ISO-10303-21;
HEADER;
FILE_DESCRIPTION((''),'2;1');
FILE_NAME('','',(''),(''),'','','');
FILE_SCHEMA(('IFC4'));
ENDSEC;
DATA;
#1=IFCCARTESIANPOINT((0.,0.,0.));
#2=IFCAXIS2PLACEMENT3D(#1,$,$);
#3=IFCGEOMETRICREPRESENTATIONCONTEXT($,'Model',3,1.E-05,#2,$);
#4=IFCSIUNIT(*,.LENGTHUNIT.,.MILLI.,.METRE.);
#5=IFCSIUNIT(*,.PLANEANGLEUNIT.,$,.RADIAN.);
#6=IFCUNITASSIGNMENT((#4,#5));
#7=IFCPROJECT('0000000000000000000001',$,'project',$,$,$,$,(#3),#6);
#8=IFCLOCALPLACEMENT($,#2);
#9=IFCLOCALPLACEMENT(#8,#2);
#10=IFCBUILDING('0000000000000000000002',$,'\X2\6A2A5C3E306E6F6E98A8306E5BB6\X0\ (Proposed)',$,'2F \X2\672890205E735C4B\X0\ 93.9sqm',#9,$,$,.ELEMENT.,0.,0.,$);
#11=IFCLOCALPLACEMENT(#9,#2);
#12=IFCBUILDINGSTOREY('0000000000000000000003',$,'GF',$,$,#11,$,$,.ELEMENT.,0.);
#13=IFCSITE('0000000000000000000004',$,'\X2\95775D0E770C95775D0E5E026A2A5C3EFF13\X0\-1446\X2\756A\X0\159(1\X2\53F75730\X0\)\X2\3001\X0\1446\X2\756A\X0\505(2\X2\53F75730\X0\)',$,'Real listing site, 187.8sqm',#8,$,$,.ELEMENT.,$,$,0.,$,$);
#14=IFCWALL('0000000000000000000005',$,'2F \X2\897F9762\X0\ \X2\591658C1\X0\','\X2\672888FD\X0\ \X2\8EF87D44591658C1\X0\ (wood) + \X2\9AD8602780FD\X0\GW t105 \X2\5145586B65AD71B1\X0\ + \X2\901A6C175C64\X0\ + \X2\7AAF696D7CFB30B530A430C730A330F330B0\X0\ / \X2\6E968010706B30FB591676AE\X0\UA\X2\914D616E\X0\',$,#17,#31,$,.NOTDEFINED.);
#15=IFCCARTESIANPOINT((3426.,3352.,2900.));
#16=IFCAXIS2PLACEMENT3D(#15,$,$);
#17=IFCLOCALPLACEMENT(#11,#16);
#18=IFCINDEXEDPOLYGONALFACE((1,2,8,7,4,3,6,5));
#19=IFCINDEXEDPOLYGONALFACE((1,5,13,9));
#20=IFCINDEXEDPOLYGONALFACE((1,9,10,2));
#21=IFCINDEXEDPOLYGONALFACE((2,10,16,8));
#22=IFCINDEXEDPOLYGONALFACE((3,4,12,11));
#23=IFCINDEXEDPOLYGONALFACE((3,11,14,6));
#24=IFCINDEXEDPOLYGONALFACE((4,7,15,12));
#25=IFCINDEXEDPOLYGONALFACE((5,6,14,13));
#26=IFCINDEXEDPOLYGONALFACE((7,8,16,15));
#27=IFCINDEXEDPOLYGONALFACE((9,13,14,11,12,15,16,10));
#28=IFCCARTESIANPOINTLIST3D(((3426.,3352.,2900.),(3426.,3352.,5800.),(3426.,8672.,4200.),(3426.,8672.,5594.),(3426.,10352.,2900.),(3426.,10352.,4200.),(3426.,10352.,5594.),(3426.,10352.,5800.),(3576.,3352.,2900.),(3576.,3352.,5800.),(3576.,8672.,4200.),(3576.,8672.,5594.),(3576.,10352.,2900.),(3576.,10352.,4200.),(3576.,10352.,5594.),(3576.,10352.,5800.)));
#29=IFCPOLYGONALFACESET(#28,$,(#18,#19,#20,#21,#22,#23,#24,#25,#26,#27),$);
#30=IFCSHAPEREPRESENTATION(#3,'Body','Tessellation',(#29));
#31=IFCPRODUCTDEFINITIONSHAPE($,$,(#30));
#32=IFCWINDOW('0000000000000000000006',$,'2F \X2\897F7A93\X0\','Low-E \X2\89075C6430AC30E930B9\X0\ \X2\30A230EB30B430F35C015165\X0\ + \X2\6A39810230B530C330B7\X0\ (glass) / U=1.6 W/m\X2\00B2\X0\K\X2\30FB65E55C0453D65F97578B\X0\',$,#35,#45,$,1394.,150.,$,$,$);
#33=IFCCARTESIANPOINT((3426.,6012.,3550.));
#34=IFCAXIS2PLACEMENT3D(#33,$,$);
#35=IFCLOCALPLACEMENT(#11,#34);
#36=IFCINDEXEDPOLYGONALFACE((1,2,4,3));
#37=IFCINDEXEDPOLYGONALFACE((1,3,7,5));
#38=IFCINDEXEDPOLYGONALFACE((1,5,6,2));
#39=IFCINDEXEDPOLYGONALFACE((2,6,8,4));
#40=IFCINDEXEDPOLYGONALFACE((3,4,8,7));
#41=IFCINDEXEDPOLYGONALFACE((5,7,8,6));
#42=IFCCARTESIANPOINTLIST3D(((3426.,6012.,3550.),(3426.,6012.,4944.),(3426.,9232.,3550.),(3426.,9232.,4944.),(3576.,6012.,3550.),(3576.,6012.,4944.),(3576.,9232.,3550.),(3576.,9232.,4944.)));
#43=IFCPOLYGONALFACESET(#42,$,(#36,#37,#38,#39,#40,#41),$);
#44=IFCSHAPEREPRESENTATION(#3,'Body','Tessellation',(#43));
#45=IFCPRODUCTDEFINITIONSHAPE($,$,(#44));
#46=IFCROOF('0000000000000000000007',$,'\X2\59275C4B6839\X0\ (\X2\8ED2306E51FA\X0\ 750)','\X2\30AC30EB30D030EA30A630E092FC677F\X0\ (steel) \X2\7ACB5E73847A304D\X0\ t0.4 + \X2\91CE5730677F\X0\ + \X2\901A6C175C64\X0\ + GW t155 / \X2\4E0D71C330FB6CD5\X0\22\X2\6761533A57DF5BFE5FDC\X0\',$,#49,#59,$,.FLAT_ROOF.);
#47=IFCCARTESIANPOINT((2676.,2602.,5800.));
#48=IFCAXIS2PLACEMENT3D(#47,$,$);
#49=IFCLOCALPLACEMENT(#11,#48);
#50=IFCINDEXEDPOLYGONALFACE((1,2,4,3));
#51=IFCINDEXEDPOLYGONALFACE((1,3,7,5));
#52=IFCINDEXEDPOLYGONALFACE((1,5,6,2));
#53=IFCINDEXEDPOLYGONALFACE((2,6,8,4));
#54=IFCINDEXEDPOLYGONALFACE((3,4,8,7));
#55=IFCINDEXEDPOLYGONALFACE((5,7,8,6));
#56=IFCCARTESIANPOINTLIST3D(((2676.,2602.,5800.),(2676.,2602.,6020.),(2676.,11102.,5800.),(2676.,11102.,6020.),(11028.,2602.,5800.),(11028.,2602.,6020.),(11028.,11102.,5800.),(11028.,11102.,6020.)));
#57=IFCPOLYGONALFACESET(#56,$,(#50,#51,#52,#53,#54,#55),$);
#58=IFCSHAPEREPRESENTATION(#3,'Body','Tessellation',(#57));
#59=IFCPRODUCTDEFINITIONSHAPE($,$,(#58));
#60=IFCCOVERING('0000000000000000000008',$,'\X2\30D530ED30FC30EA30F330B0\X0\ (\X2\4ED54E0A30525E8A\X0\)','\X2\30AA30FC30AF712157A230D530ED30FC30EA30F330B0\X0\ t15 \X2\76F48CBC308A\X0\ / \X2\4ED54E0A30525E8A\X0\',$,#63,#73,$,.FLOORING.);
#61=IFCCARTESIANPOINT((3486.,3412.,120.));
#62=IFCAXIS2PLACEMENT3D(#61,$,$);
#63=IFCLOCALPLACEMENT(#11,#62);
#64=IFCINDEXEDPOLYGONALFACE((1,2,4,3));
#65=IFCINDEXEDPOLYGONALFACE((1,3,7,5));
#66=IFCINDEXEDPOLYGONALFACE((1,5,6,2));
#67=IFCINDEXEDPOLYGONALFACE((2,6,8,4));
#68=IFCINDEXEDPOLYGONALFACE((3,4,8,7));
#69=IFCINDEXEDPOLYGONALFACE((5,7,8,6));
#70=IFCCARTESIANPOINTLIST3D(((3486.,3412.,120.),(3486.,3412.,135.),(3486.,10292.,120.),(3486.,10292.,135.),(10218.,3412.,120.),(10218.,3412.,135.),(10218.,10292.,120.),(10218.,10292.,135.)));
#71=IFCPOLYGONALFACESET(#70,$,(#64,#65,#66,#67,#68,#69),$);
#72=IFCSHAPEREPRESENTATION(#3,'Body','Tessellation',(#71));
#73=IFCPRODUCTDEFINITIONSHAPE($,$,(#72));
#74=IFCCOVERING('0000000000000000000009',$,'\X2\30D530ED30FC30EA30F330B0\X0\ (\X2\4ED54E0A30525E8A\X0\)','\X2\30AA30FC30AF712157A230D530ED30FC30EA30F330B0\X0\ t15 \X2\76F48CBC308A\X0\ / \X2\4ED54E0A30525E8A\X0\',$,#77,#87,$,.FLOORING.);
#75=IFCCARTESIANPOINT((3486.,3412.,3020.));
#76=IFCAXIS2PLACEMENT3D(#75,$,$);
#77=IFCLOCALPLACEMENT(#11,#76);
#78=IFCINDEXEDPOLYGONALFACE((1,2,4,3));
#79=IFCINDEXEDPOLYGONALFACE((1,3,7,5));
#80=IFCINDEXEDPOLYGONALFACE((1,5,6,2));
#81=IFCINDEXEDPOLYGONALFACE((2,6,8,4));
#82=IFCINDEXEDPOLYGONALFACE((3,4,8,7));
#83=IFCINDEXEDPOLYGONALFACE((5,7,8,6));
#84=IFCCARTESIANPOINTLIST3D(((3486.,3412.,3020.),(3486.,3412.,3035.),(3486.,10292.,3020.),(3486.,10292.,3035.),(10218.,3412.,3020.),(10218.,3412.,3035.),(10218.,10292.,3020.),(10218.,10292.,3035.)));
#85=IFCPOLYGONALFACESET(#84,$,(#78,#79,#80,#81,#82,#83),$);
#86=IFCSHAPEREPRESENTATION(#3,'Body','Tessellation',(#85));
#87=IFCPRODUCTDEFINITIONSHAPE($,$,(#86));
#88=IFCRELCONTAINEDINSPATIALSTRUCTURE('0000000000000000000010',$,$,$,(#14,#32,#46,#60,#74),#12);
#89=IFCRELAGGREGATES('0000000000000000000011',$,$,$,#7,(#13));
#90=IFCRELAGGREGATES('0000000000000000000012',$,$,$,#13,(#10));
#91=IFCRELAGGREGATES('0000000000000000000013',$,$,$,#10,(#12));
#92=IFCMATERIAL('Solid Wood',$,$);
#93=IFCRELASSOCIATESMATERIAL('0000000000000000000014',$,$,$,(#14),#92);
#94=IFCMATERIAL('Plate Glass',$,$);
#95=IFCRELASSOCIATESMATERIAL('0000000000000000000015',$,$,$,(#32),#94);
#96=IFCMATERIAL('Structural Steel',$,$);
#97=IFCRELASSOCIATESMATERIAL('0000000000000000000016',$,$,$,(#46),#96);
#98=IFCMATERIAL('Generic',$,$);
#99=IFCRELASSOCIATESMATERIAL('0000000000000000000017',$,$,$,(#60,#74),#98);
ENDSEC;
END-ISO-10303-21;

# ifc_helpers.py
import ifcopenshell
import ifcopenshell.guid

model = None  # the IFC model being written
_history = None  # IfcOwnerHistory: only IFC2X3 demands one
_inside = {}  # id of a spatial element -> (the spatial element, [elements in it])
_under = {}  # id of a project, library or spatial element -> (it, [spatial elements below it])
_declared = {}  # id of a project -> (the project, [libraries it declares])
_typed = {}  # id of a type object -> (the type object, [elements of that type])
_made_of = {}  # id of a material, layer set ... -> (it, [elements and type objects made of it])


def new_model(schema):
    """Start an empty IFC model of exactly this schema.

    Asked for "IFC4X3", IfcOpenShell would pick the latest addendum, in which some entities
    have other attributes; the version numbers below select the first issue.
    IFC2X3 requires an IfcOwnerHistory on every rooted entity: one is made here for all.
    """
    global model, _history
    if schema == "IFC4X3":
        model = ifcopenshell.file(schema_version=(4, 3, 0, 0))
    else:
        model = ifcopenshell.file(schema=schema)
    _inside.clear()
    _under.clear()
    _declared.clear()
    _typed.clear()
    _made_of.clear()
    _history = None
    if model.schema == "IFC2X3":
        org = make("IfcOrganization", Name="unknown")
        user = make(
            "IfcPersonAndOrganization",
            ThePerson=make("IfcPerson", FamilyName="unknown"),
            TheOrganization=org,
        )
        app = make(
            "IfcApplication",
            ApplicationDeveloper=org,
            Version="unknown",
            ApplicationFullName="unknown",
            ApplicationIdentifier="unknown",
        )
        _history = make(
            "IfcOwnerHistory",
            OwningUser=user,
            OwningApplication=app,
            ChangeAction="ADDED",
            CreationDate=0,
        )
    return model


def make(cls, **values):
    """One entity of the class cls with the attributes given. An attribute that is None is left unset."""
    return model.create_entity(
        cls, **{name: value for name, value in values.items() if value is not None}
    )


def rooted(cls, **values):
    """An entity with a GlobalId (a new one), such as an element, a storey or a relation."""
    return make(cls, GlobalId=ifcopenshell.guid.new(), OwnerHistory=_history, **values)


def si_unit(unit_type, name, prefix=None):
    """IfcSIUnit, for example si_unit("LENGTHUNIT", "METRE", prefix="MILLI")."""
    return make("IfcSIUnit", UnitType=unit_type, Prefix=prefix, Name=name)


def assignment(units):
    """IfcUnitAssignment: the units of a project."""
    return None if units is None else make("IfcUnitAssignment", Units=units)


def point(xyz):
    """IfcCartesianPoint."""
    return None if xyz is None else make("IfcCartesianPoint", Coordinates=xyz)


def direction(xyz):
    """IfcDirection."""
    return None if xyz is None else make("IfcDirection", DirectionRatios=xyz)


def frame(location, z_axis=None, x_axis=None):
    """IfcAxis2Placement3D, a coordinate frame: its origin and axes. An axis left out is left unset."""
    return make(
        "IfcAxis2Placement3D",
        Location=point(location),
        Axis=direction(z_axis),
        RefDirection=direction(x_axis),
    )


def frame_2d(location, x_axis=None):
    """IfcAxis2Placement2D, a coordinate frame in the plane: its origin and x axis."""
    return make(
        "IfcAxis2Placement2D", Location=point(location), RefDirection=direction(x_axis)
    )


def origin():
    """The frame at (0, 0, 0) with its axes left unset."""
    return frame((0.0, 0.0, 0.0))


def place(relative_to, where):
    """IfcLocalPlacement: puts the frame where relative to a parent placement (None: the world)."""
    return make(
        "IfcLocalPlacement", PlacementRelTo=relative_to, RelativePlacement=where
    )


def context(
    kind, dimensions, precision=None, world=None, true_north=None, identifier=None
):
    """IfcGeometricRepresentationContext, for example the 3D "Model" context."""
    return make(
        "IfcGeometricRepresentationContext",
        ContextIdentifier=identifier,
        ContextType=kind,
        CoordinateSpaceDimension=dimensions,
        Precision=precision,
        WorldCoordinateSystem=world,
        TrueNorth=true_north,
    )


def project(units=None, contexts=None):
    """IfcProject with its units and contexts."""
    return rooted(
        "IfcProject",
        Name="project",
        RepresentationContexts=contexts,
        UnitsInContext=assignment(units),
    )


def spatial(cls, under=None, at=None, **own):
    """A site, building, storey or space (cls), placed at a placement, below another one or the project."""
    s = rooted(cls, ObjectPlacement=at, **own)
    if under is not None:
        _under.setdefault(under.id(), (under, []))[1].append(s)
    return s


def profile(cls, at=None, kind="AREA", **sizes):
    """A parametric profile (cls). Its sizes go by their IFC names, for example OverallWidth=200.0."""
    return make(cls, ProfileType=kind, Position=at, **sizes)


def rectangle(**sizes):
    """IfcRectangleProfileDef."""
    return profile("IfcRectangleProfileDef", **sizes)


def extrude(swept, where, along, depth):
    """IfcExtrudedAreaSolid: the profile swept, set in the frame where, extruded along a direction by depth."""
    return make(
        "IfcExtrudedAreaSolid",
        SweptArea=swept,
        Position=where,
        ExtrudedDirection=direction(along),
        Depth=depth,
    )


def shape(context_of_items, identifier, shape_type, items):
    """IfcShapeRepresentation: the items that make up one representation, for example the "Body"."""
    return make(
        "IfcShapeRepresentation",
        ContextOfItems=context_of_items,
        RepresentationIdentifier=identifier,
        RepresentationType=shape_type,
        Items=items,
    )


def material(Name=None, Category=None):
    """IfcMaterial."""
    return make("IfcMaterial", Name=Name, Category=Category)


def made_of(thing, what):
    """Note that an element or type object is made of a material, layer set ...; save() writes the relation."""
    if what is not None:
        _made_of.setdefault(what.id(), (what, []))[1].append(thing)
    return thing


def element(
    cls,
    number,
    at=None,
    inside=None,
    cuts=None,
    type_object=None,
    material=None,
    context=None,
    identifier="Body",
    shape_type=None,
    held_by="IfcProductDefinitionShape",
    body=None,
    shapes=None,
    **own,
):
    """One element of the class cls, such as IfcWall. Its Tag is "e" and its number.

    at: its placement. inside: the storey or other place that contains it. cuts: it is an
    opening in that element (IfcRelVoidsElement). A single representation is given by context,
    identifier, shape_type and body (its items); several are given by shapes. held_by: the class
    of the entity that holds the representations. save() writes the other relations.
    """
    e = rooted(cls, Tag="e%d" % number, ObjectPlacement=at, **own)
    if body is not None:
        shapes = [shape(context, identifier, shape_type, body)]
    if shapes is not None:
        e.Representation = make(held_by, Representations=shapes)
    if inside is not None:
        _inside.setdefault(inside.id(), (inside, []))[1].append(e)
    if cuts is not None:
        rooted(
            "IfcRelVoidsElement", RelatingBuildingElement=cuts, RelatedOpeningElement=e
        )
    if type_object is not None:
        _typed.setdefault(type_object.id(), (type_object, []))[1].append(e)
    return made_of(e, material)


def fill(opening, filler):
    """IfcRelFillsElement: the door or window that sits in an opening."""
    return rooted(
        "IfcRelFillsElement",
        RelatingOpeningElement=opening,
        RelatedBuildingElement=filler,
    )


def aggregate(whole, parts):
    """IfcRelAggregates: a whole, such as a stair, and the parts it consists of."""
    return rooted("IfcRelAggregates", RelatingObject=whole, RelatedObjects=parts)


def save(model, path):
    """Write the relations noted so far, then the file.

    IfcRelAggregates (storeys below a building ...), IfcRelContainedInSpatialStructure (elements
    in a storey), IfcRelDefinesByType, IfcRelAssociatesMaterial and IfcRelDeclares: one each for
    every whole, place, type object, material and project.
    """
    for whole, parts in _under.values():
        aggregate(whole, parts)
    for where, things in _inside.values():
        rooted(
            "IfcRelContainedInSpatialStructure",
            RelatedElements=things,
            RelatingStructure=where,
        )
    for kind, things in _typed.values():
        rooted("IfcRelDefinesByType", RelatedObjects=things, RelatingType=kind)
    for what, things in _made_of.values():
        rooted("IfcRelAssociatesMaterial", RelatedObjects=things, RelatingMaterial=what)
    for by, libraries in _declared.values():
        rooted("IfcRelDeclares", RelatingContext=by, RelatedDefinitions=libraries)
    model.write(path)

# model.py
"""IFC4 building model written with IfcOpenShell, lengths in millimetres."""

from ifc_helpers import new_model, si_unit, frame, frame_2d, origin, place, context, project, spatial, rectangle, extrude, material, element, fill, save


model = new_model("IFC4")

# Units and contexts
model_context = context("Model", 3, precision=1e-05, world=origin())
ifc_project = project(units=[si_unit("LENGTHUNIT", "METRE", prefix="MILLI"), si_unit("PLANEANGLEUNIT", "RADIAN")], contexts=[model_context])

# Site, building, storey
site_placement = place(None, origin())
site = spatial("IfcSite", under=ifc_project, at=site_placement, Name="長崎県長崎市横尾３-1446番159(1号地)、1446番505(2号地)", ObjectType="Real listing site, 187.8sqm", CompositionType="ELEMENT", RefElevation=0.0)
building_placement = place(site_placement, origin())
building = spatial("IfcBuilding", under=site, at=building_placement, Name="横尾の潮風の家 (Proposed)", ObjectType="2F 木造平屋 93.9sqm", CompositionType="ELEMENT", ElevationOfRefHeight=0.0, ElevationOfTerrain=0.0)
storey_placement = place(building_placement, origin())
storey = spatial("IfcBuildingStorey", under=building, at=storey_placement, Name="GF", CompositionType="ELEMENT", Elevation=0.0)

# Shared definitions
ifc_material_1 = material(Name="Solid Wood")

# Shared definitions
ifc_material_2 = material(Name="Plate Glass")

# Wall, opening, window
wall_1_placement = place(storey_placement, frame((3426.0, 3352.0, 2900.0)))
wall_1 = element("IfcWall", 1, at=wall_1_placement, inside=storey, material=ifc_material_1, Name="2F 西面 外壁", Description="木製 軸組外壁 (wood) + 高性能GW t105 充填断熱 + 通気層 + 窯業系サイディング / 準耐火・外皮UA配慮", PredefinedType="NOTDEFINED", context=model_context, shape_type="SweptSolid", body=[
    extrude(rectangle(XDim=150.0, YDim=7000.0, at=frame_2d((75.0, 3500.0))), frame((3426.0, 3352.0, 2900.0)), (0.0, 0.0, 1.0), 2900.0),
])
opening_1_placement = place(storey_placement, frame((3426.0, 6012.0, 3550.0)))
opening_1 = element("IfcOpeningElement", 2, at=opening_1_placement, cuts=wall_1, PredefinedType="NOTDEFINED", context=model_context, shape_type="SweptSolid", body=[
    extrude(rectangle(XDim=150.0, YDim=3220.0, at=frame_2d((75.0, 1610.0))), frame((3426.0, 6012.0, 3550.0)), (0.0, 0.0, 1.0), 1394.0),
])
window_1_placement = place(storey_placement, frame((3426.0, 6012.0, 3550.0)))
window_1 = element("IfcWindow", 3, at=window_1_placement, inside=storey, material=ifc_material_2, Name="2F 西窓", Description="Low-E 複層ガラス アルゴン封入 + 樹脂サッシ (glass) / U=1.6 W/m²K・日射取得型", OverallHeight=1394.0, OverallWidth=150.0, context=model_context, shape_type="SweptSolid", body=[
    extrude(rectangle(XDim=150.0, YDim=3220.0, at=frame_2d((75.0, 1610.0))), frame((3426.0, 6012.0, 3550.0)), (0.0, 0.0, 1.0), 1394.0),
])
fill(opening_1, window_1)

# Roof
ifc_material_3 = material(Name="Structural Steel")
roof_placement = place(storey_placement, frame((2676.0, 2602.0, 5800.0)))
element("IfcRoof", 4, at=roof_placement, inside=storey, material=ifc_material_3, Name="大屋根 (軒の出 750)", Description="ガルバリウム鋼板 (steel) 立平葺き t0.4 + 野地板 + 通気層 + GW t155 / 不燃・法22条区域対応", PredefinedType="FLAT_ROOF", context=model_context, shape_type="SweptSolid", body=[
    extrude(rectangle(XDim=8352.0, YDim=8500.0, at=frame_2d((4176.0, 4250.0))), frame((2676.0, 2602.0, 5800.0)), (0.0, 0.0, 1.0), 220.0),
])

# Coverings
ifc_material_4 = material(Name="Generic")
covering_1_placement = place(storey_placement, frame((3486.0, 3412.0, 120.0)))
element("IfcCovering", 5, at=covering_1_placement, inside=storey, material=ifc_material_4, Name="フローリング (仕上げ床)", Description="オーク無垢フローリング t15 直貼り / 仕上げ床", PredefinedType="FLOORING", context=model_context, shape_type="SweptSolid", body=[
    extrude(rectangle(XDim=6732.0, YDim=6880.0, at=frame_2d((3366.0, 3440.0))), frame((3486.0, 3412.0, 120.0)), (0.0, 0.0, 1.0), 15.0),
])
covering_2_placement = place(storey_placement, frame((3486.0, 3412.0, 3020.0)))
element("IfcCovering", 6, at=covering_2_placement, inside=storey, material=ifc_material_4, Name="フローリング (仕上げ床)", Description="オーク無垢フローリング t15 直貼り / 仕上げ床", PredefinedType="FLOORING", context=model_context, shape_type="SweptSolid", body=[
    extrude(rectangle(XDim=6732.0, YDim=6880.0, at=frame_2d((3366.0, 3440.0))), frame((3486.0, 3412.0, 3020.0)), (0.0, 0.0, 1.0), 15.0),
])

save(model, "model.ifc")
